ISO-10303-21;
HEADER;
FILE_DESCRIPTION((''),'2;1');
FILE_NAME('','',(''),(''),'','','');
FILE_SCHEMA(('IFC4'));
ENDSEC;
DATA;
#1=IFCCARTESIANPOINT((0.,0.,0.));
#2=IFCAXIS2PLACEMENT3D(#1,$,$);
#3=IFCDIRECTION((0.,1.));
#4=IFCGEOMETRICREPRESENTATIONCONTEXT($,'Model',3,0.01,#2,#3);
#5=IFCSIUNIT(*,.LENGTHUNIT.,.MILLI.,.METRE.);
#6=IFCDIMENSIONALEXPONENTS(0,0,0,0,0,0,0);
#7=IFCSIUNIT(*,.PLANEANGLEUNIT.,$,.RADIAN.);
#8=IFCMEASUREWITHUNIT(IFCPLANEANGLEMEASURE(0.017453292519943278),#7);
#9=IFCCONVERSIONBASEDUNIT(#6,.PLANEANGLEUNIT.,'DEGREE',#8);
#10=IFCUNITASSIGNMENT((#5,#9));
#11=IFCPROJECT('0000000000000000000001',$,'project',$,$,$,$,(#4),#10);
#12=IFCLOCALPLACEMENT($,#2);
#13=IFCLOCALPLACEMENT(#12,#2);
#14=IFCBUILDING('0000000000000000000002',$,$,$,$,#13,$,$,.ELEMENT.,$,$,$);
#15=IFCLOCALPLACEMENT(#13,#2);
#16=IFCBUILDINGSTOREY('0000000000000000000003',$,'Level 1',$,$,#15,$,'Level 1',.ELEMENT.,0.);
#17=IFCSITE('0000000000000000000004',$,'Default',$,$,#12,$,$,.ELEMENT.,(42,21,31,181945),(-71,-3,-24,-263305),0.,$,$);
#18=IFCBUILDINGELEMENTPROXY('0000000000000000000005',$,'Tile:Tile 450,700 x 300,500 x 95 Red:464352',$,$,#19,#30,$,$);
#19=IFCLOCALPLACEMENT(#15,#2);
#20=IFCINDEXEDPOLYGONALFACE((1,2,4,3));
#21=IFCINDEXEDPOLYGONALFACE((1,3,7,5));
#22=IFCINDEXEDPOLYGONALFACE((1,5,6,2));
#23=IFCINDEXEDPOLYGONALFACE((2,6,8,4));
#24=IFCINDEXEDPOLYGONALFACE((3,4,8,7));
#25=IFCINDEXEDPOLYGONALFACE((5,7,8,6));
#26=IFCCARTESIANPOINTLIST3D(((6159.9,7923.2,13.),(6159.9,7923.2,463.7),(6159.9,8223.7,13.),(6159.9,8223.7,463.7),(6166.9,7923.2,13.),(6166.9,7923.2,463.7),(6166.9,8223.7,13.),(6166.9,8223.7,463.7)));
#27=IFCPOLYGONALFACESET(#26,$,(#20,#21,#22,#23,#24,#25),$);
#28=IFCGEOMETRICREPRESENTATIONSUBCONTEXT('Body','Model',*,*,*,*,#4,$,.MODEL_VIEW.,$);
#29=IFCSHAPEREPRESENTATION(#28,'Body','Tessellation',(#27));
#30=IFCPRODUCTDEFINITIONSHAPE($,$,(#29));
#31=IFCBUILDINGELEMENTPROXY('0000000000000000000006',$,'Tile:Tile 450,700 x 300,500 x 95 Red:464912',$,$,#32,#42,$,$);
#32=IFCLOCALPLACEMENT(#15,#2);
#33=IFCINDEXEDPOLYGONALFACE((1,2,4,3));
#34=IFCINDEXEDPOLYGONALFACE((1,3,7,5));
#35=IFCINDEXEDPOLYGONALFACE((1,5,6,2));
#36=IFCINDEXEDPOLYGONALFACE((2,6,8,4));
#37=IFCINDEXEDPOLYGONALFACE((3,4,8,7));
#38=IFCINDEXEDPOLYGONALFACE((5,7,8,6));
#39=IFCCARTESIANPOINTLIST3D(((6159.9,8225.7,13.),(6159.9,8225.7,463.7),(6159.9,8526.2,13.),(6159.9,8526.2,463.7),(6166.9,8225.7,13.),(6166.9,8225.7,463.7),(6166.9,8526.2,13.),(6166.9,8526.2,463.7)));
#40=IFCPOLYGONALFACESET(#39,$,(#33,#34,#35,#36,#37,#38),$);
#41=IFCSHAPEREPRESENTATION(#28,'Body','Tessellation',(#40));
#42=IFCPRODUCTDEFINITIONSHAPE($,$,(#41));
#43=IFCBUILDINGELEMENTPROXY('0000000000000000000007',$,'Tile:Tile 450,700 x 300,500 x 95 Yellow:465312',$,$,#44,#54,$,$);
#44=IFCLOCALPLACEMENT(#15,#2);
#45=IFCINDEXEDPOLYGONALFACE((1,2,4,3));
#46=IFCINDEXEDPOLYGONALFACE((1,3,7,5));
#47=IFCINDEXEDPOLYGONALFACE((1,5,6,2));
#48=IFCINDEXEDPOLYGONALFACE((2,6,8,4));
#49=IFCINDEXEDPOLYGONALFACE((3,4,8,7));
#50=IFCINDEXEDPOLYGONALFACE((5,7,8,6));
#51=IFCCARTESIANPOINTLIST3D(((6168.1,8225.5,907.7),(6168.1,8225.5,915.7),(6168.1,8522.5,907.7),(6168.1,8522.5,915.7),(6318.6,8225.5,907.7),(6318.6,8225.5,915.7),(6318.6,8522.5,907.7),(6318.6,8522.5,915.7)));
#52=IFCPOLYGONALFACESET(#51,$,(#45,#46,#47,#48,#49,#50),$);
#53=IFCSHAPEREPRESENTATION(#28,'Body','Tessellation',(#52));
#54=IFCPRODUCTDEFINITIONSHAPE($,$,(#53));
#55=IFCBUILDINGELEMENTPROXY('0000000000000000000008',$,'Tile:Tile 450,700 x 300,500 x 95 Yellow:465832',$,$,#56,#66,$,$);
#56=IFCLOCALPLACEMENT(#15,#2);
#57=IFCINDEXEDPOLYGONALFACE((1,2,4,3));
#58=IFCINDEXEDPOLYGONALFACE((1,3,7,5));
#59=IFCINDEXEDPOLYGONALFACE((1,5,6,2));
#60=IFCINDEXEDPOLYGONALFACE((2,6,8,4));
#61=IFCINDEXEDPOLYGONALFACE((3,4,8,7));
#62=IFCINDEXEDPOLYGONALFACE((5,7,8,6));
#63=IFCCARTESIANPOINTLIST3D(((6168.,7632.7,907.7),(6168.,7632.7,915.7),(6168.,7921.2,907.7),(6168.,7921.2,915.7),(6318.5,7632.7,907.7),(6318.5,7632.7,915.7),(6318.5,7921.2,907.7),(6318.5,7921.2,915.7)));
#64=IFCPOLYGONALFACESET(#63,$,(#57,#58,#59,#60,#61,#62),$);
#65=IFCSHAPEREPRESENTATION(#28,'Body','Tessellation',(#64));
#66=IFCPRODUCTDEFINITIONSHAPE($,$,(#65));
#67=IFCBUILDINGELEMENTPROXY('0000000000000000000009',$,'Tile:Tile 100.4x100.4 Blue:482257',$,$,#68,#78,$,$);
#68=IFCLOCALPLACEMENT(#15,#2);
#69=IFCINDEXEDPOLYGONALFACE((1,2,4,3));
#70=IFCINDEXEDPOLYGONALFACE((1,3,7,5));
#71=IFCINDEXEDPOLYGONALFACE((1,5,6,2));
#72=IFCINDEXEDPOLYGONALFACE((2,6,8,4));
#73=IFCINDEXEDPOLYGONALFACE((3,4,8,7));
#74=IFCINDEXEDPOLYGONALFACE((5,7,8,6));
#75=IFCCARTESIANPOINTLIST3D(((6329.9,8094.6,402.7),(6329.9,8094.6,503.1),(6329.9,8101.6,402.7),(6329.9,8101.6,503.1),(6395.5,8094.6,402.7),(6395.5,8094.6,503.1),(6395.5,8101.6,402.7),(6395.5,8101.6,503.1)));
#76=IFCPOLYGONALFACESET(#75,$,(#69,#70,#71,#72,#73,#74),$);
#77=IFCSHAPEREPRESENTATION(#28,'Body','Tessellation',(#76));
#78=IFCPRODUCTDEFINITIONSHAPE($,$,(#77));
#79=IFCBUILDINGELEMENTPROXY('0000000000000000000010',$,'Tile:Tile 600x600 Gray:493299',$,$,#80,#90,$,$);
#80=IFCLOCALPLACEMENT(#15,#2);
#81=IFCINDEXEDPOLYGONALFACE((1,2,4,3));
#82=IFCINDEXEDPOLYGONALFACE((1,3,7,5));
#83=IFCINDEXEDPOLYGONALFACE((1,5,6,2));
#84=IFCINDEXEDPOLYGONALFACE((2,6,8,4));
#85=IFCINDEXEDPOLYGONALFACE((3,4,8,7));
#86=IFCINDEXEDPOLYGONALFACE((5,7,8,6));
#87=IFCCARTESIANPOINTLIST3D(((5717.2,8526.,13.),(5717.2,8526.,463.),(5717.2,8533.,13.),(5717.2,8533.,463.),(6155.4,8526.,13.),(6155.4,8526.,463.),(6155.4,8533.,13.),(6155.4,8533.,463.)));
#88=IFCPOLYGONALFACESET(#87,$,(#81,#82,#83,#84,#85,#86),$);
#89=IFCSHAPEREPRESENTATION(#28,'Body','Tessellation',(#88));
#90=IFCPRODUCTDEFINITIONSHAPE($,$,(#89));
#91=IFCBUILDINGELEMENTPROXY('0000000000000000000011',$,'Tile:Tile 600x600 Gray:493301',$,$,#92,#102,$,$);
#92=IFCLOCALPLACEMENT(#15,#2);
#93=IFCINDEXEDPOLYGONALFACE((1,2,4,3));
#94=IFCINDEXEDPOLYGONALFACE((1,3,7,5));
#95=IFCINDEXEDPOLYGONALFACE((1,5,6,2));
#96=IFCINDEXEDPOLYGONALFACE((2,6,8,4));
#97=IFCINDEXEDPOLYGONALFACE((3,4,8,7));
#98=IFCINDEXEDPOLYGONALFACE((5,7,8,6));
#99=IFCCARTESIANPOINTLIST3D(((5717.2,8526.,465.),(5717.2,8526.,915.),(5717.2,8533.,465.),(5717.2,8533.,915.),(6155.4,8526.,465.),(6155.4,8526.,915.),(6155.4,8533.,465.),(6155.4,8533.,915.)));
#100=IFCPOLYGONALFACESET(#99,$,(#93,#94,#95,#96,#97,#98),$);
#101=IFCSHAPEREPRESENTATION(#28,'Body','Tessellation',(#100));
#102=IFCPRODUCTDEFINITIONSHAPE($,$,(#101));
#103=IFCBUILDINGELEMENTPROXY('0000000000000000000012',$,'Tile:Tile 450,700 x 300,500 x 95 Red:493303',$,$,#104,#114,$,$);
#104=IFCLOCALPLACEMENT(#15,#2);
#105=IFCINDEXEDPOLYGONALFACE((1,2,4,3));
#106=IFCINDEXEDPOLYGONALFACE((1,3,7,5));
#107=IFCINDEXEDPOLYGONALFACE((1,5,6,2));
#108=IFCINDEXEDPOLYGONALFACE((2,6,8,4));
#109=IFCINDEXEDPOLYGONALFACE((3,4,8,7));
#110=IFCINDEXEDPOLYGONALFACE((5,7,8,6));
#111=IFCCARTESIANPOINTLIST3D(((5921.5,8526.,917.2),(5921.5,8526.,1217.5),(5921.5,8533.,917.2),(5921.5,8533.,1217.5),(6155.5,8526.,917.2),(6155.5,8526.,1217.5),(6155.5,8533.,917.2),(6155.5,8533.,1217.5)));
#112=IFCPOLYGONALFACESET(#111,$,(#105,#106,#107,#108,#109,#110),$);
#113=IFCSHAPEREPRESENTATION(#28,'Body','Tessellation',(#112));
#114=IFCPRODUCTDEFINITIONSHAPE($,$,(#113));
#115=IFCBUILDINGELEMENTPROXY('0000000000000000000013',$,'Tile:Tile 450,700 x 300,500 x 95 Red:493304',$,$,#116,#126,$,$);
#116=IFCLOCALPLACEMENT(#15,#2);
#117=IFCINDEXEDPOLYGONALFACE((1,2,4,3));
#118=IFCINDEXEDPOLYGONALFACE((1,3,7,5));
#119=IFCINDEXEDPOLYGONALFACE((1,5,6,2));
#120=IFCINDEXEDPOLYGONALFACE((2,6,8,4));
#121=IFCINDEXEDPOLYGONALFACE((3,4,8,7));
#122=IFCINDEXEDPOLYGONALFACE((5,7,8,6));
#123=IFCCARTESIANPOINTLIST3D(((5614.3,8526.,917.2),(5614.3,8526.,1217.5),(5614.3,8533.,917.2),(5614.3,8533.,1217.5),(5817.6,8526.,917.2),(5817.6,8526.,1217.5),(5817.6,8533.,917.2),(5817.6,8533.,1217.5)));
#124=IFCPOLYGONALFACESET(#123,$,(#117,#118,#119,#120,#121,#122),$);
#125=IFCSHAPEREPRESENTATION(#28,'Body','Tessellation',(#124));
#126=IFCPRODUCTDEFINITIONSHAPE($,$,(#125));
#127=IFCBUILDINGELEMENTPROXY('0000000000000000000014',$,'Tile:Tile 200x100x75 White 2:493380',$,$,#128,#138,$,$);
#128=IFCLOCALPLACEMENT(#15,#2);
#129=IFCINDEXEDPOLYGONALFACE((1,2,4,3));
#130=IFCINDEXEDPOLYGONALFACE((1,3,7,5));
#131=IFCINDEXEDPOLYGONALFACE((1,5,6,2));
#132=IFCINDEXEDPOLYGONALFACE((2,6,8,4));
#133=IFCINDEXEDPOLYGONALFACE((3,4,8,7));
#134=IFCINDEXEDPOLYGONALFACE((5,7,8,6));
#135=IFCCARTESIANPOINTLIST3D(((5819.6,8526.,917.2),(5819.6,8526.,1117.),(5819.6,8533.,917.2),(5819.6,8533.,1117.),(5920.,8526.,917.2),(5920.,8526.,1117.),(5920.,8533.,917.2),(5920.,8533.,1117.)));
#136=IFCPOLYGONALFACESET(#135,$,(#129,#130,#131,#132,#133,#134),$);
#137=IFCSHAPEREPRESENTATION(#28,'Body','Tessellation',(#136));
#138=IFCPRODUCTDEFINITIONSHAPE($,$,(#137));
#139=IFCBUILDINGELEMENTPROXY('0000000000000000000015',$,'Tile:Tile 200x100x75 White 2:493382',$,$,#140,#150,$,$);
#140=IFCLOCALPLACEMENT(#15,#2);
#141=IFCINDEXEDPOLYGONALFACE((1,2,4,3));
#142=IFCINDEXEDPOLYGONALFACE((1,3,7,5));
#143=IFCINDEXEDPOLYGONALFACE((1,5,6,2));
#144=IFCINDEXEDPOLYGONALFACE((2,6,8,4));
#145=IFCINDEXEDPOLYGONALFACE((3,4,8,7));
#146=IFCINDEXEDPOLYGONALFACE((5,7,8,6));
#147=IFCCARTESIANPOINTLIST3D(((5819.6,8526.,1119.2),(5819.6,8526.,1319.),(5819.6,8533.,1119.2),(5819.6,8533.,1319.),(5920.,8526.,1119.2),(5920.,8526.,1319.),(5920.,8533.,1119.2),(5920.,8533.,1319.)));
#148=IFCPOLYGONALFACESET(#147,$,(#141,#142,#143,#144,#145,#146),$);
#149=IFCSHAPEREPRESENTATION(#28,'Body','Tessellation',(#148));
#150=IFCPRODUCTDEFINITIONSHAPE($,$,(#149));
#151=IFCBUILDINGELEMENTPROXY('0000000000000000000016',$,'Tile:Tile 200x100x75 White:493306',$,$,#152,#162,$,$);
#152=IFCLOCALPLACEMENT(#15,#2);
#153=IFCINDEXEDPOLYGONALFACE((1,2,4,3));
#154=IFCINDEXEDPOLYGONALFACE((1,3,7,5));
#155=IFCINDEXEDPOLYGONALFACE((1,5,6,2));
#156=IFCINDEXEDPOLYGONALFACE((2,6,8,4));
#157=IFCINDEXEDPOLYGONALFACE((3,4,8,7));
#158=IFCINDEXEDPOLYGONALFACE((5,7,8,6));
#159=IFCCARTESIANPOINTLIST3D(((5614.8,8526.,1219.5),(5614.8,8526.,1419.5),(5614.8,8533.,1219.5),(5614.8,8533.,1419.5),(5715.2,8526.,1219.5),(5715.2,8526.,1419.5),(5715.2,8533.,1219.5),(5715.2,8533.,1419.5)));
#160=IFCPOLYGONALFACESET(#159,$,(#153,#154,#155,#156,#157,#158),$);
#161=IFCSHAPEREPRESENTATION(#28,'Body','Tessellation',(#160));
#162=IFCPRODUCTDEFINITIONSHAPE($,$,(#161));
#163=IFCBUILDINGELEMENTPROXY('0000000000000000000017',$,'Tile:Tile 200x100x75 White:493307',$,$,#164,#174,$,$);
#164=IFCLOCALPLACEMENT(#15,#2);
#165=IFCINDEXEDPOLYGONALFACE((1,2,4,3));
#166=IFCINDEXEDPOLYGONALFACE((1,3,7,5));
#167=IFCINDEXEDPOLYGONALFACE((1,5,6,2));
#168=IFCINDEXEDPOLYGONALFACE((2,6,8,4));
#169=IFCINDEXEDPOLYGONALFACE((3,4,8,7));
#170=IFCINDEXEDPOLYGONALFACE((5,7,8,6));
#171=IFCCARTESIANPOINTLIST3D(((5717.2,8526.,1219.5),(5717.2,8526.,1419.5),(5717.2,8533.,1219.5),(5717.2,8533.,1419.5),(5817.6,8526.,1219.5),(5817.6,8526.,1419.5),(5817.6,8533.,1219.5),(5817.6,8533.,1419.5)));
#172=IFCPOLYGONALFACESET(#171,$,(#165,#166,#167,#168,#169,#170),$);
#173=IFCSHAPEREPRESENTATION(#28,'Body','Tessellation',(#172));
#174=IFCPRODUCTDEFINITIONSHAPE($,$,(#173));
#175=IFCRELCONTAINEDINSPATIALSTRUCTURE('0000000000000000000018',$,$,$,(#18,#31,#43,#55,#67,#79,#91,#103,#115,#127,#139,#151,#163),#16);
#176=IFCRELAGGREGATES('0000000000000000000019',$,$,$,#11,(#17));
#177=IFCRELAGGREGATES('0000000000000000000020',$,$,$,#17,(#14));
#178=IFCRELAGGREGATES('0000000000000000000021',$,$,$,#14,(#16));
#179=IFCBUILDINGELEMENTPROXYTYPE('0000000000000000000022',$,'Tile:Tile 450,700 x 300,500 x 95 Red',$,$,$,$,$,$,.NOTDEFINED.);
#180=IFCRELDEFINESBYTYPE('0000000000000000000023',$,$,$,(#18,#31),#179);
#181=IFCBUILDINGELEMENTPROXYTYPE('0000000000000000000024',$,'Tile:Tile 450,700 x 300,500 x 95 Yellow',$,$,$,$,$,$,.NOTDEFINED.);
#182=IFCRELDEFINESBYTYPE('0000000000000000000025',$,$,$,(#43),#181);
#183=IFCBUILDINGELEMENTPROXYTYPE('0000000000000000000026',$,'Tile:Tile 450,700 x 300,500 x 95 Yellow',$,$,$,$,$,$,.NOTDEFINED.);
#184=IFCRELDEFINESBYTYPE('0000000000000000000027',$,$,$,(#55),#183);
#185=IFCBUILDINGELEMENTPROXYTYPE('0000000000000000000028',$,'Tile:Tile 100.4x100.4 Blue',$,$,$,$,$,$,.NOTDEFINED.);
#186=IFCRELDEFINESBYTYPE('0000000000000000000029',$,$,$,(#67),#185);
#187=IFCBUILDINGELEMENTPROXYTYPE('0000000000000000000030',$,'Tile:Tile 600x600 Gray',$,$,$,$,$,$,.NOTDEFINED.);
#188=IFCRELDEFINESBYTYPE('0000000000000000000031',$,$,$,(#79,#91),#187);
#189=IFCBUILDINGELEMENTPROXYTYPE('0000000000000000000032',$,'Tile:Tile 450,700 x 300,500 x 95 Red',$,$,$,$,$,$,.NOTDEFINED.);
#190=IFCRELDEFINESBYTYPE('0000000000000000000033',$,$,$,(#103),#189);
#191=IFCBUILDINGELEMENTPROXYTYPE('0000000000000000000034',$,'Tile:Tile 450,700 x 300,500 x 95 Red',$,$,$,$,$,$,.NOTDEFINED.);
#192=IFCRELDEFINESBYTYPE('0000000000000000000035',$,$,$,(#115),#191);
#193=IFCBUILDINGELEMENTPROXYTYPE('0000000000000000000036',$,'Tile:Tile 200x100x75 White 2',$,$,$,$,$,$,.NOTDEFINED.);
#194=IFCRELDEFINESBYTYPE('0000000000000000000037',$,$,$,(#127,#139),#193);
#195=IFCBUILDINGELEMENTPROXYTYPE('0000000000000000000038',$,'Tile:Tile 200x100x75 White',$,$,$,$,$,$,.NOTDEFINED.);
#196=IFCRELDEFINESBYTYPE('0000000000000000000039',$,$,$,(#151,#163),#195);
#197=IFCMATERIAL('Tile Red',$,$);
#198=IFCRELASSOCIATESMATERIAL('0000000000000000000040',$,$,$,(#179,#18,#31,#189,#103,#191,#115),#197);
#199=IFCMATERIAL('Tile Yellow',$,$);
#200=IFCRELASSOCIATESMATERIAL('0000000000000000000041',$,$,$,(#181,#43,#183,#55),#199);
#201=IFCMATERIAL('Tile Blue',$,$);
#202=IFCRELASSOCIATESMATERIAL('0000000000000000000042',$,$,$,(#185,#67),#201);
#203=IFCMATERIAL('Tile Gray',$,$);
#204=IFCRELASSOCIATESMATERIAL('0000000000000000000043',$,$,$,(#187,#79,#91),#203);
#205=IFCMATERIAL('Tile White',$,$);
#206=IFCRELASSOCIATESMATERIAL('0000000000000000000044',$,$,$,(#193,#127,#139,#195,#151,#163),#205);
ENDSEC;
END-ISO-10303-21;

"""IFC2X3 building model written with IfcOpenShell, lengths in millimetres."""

from ifc_helpers import new_model, entity, si_unit, converted_unit, direction, frame, frame_2d, origin, origin_2d_with_axis, place, context, subcontext, project, spatial, rectangle, extrude, source, transform, mapped, material, type_object, type_shapes, element, save


model = new_model("IFC2X3")

# Units and contexts
model_context = context("Model", 3, precision=0.01, world=origin(), true_north=direction((0.0, 1.0)))
body_context = subcontext(model_context, "Body", "Model", "MODEL_VIEW")
ifc_project = project(units=[si_unit("LENGTHUNIT", "METRE", prefix="MILLI"), converted_unit("PLANEANGLEUNIT", "DEGREE", entity("IfcPlaneAngleMeasure", 0.017453292519943278), si_unit("PLANEANGLEUNIT", "RADIAN"), dimensions=[0, 0, 0, 0, 0, 0, 0])], contexts=[model_context])

# Site, building, storey
site_placement = place(None, origin())
site = spatial("IfcSite", under=ifc_project, at=site_placement, Name="Default", CompositionType="ELEMENT", RefLatitude=(42, 21, 31, 181945), RefLongitude=(-71, -3, -24, -263305), RefElevation=0.0)
building_placement = place(site_placement, origin())
building = spatial("IfcBuilding", under=site, at=building_placement, CompositionType="ELEMENT")
storey_placement = place(building_placement, origin())
storey = spatial("IfcBuildingStorey", under=building, at=storey_placement, Name="Level 1", LongName="Level 1", CompositionType="ELEMENT", Elevation=0.0)

# Building element proxies
ifc_material_1 = material(Name="Tile Red")
building_element_proxy_type_1 = type_object("IfcBuildingElementProxyType", Name="Tile:Tile 450,700 x 300,500 x 95 Red", PredefinedType="NOTDEFINED", material=ifc_material_1)
shared_shape_1 = source(origin(), body_context, "Body", "SweptSolid", [
    extrude(rectangle(XDim=300.5, YDim=450.7, at=frame_2d((0.0, 0.0), x_axis=(1.0, 0.0))), frame((-150.2, 225.4, 0.0)), (0.0, 0.0, 1.0), 7.0),
])
type_shapes(building_element_proxy_type_1, [shared_shape_1])
for number, where, z_axis, x_axis, name in (
    (1, (6166.9, 7923.2, 13.0), (-1.0, 0.0, 0.0), (0.0, -1.0, 0.0), "Tile:Tile 450,700 x 300,500 x 95 Red:464352"),
    (2, (6166.9, 8225.7, 13.0), (-1.0, 0.0, 0.0), (0.0, -1.0, 0.0), "Tile:Tile 450,700 x 300,500 x 95 Red:464912"),
):
    element("IfcBuildingElementProxy", number, at=place(storey_placement, frame(where, z_axis=z_axis, x_axis=x_axis)), inside=storey, type_object=building_element_proxy_type_1, material=ifc_material_1, Name=name, context=body_context, shape_type="MappedRepresentation", body=[
        mapped(shared_shape_1, transform((0.0, 0.0, 0.0), scale=1.0)),
    ])
ifc_material_2 = material(Name="Tile Yellow")
building_element_proxy_type_2 = type_object("IfcBuildingElementProxyType", Name="Tile:Tile 450,700 x 300,500 x 95 Yellow", PredefinedType="NOTDEFINED", material=ifc_material_2)
shared_shape_2 = source(origin(), body_context, "Body", "SweptSolid", [
    extrude(rectangle(XDim=150.5, YDim=297.0, at=frame_2d((0.0, 0.0), x_axis=(1.0, 0.0))), frame((-75.2, -148.5, 0.0), z_axis=(0.0, 0.0, 1.0), x_axis=(-1.0, 0.0, 0.0)), (0.0, 0.0, 1.0), 8.0),
])
type_shapes(building_element_proxy_type_2, [shared_shape_2])
proxy_1_placement = place(storey_placement, frame((6318.6, 8522.5, 907.7)))
element("IfcBuildingElementProxy", 3, at=proxy_1_placement, inside=storey, type_object=building_element_proxy_type_2, material=ifc_material_2, Name="Tile:Tile 450,700 x 300,500 x 95 Yellow:465312", context=body_context, shape_type="MappedRepresentation", body=[
    mapped(shared_shape_2, transform((0.0, 0.0, 0.0), scale=1.0)),
])
building_element_proxy_type_3 = type_object("IfcBuildingElementProxyType", Name="Tile:Tile 450,700 x 300,500 x 95 Yellow", PredefinedType="NOTDEFINED", material=ifc_material_2)
shared_shape_3 = source(origin(), body_context, "Body", "SweptSolid", [
    extrude(rectangle(XDim=150.5, YDim=288.5, at=origin_2d_with_axis()), frame((-75.2, -144.3, 0.0), z_axis=(0.0, 0.0, 1.0), x_axis=(-1.0, 0.0, 0.0)), (0.0, 0.0, 1.0), 8.0),
])
type_shapes(building_element_proxy_type_3, [shared_shape_3])
proxy_2_placement = place(storey_placement, frame((6318.5, 7921.2, 907.7)))
element("IfcBuildingElementProxy", 4, at=proxy_2_placement, inside=storey, type_object=building_element_proxy_type_3, material=ifc_material_2, Name="Tile:Tile 450,700 x 300,500 x 95 Yellow:465832", context=body_context, shape_type="MappedRepresentation", body=[
    mapped(shared_shape_3, transform((0.0, 0.0, 0.0), scale=1.0)),
])
ifc_material_3 = material(Name="Tile Blue")
building_element_proxy_type_4 = type_object("IfcBuildingElementProxyType", Name="Tile:Tile 100.4x100.4 Blue", PredefinedType="NOTDEFINED", material=ifc_material_3)
shared_shape_4 = source(origin(), body_context, "Body", "SweptSolid", [
    extrude(rectangle(XDim=65.6, YDim=100.4, at=frame_2d((0.0, 0.0), x_axis=(1.0, 0.0))), frame((-32.8, -50.2, 0.0), z_axis=(0.0, 0.0, 1.0), x_axis=(-1.0, 0.0, 0.0)), (0.0, 0.0, 1.0), 7.0),
])
type_shapes(building_element_proxy_type_4, [shared_shape_4])
proxy_3_placement = place(storey_placement, frame((6329.9, 8101.6, 402.7), z_axis=(0.0, -1.0, 0.0), x_axis=(-1.0, 0.0, 0.0)))
element("IfcBuildingElementProxy", 5, at=proxy_3_placement, inside=storey, type_object=building_element_proxy_type_4, material=ifc_material_3, Name="Tile:Tile 100.4x100.4 Blue:482257", context=body_context, shape_type="MappedRepresentation", body=[
    mapped(shared_shape_4, transform((0.0, 0.0, 0.0), scale=1.0)),
])
ifc_material_4 = material(Name="Tile Gray")
building_element_proxy_type_5 = type_object("IfcBuildingElementProxyType", Name="Tile:Tile 600x600 Gray", PredefinedType="NOTDEFINED", material=ifc_material_4)
shared_shape_5 = source(origin(), body_context, "Body", "SweptSolid", [
    extrude(rectangle(XDim=438.2, YDim=450.0, at=origin_2d_with_axis()), frame((-219.1, -225.0, 0.0), z_axis=(0.0, 0.0, 1.0), x_axis=(-1.0, 0.0, 0.0)), (0.0, 0.0, 1.0), 7.0),
])
type_shapes(building_element_proxy_type_5, [shared_shape_5])
for number, where, z_axis, x_axis, name in (
    (6, (6155.4, 8533.0, 463.0), (0.0, -1.0, 0.0), (1.0, 0.0, 0.0), "Tile:Tile 600x600 Gray:493299"),
    (7, (6155.4, 8533.0, 915.0), (0.0, -1.0, 0.0), (1.0, 0.0, 0.0), "Tile:Tile 600x600 Gray:493301"),
):
    element("IfcBuildingElementProxy", number, at=place(storey_placement, frame(where, z_axis=z_axis, x_axis=x_axis)), inside=storey, type_object=building_element_proxy_type_5, material=ifc_material_4, Name=name, context=body_context, shape_type="MappedRepresentation", body=[
        mapped(shared_shape_5, transform((0.0, 0.0, 0.0), scale=1.0)),
    ])
building_element_proxy_type_6 = type_object("IfcBuildingElementProxyType", Name="Tile:Tile 450,700 x 300,500 x 95 Red", PredefinedType="NOTDEFINED", material=ifc_material_1)
shared_shape_6 = source(origin(), body_context, "Body", "SweptSolid", [
    extrude(rectangle(XDim=233.9, YDim=300.3, at=frame_2d((0.0, 0.0), x_axis=(1.0, 0.0))), frame((-117.0, -150.2, 0.0), z_axis=(0.0, 0.0, 1.0), x_axis=(-1.0, 0.0, 0.0)), (0.0, 0.0, 1.0), 7.0),
])
type_shapes(building_element_proxy_type_6, [shared_shape_6])
proxy_4_placement = place(storey_placement, frame((6155.5, 8533.0, 1217.5), z_axis=(0.0, -1.0, 0.0), x_axis=(1.0, 0.0, 0.0)))
element("IfcBuildingElementProxy", 8, at=proxy_4_placement, inside=storey, type_object=building_element_proxy_type_6, material=ifc_material_1, Name="Tile:Tile 450,700 x 300,500 x 95 Red:493303", context=body_context, shape_type="MappedRepresentation", body=[
    mapped(shared_shape_6, transform((0.0, 0.0, 0.0), scale=1.0)),
])
building_element_proxy_type_7 = type_object("IfcBuildingElementProxyType", Name="Tile:Tile 450,700 x 300,500 x 95 Red", PredefinedType="NOTDEFINED", material=ifc_material_1)
shared_shape_7 = source(origin(), body_context, "Body", "SweptSolid", [
    extrude(rectangle(XDim=203.3, YDim=300.3, at=frame_2d((0.0, 0.0), x_axis=(1.0, 0.0))), frame((-101.6, -150.2, 0.0), z_axis=(0.0, 0.0, 1.0), x_axis=(-1.0, 0.0, 0.0)), (0.0, 0.0, 1.0), 7.0),
])
type_shapes(building_element_proxy_type_7, [shared_shape_7])
proxy_5_placement = place(storey_placement, frame((5817.6, 8533.0, 1217.5), z_axis=(0.0, -1.0, 0.0), x_axis=(1.0, 0.0, 0.0)))
element("IfcBuildingElementProxy", 9, at=proxy_5_placement, inside=storey, type_object=building_element_proxy_type_7, material=ifc_material_1, Name="Tile:Tile 450,700 x 300,500 x 95 Red:493304", context=body_context, shape_type="MappedRepresentation", body=[
    mapped(shared_shape_7, transform((0.0, 0.0, 0.0), scale=1.0)),
])
ifc_material_5 = material(Name="Tile White")
building_element_proxy_type_8 = type_object("IfcBuildingElementProxyType", Name="Tile:Tile 200x100x75 White 2", PredefinedType="NOTDEFINED", material=ifc_material_5)
shared_shape_8 = source(origin(), body_context, "Body", "SweptSolid", [
    extrude(rectangle(XDim=199.8, YDim=100.4, at=frame_2d((0.0, 0.0), x_axis=(1.0, 0.0))), frame((-50.2, -99.9, 0.0), z_axis=(0.0, 0.0, 1.0), x_axis=(0.0, -1.0, 0.0)), (0.0, 0.0, 1.0), 7.0),
])
type_shapes(building_element_proxy_type_8, [shared_shape_8])
for number, where, z_axis, x_axis, name in (
    (10, (5920.0, 8533.0, 1117.0), (0.0, -1.0, 0.0), (1.0, 0.0, 0.0), "Tile:Tile 200x100x75 White 2:493380"),
    (11, (5920.0, 8533.0, 1319.0), (0.0, -1.0, 0.0), (1.0, 0.0, 0.0), "Tile:Tile 200x100x75 White 2:493382"),
):
    element("IfcBuildingElementProxy", number, at=place(storey_placement, frame(where, z_axis=z_axis, x_axis=x_axis)), inside=storey, type_object=building_element_proxy_type_8, material=ifc_material_5, Name=name, context=body_context, shape_type="MappedRepresentation", body=[
        mapped(shared_shape_8, transform((0.0, 0.0, 0.0), scale=1.0)),
    ])
building_element_proxy_type_9 = type_object("IfcBuildingElementProxyType", Name="Tile:Tile 200x100x75 White", PredefinedType="NOTDEFINED", material=ifc_material_5)
shared_shape_9 = source(origin(), body_context, "Body", "SweptSolid", [
    extrude(rectangle(XDim=200.0, YDim=100.4, at=frame_2d((0.0, 0.0), x_axis=(1.0, 0.0))), frame((-50.2, -100.0, 0.0), z_axis=(0.0, 0.0, 1.0), x_axis=(0.0, -1.0, 0.0)), (0.0, 0.0, 1.0), 7.0),
])
type_shapes(building_element_proxy_type_9, [shared_shape_9])
for number, where, z_axis, x_axis, name in (
    (12, (5715.2, 8533.0, 1419.5), (0.0, -1.0, 0.0), (1.0, 0.0, 0.0), "Tile:Tile 200x100x75 White:493306"),
    (13, (5817.6, 8533.0, 1419.5), (0.0, -1.0, 0.0), (1.0, 0.0, 0.0), "Tile:Tile 200x100x75 White:493307"),
):
    element("IfcBuildingElementProxy", number, at=place(storey_placement, frame(where, z_axis=z_axis, x_axis=x_axis)), inside=storey, type_object=building_element_proxy_type_9, material=ifc_material_5, Name=name, context=body_context, shape_type="MappedRepresentation", body=[
        mapped(shared_shape_9, transform((0.0, 0.0, 0.0), scale=1.0)),
    ])

save(model, "model.ifc")
